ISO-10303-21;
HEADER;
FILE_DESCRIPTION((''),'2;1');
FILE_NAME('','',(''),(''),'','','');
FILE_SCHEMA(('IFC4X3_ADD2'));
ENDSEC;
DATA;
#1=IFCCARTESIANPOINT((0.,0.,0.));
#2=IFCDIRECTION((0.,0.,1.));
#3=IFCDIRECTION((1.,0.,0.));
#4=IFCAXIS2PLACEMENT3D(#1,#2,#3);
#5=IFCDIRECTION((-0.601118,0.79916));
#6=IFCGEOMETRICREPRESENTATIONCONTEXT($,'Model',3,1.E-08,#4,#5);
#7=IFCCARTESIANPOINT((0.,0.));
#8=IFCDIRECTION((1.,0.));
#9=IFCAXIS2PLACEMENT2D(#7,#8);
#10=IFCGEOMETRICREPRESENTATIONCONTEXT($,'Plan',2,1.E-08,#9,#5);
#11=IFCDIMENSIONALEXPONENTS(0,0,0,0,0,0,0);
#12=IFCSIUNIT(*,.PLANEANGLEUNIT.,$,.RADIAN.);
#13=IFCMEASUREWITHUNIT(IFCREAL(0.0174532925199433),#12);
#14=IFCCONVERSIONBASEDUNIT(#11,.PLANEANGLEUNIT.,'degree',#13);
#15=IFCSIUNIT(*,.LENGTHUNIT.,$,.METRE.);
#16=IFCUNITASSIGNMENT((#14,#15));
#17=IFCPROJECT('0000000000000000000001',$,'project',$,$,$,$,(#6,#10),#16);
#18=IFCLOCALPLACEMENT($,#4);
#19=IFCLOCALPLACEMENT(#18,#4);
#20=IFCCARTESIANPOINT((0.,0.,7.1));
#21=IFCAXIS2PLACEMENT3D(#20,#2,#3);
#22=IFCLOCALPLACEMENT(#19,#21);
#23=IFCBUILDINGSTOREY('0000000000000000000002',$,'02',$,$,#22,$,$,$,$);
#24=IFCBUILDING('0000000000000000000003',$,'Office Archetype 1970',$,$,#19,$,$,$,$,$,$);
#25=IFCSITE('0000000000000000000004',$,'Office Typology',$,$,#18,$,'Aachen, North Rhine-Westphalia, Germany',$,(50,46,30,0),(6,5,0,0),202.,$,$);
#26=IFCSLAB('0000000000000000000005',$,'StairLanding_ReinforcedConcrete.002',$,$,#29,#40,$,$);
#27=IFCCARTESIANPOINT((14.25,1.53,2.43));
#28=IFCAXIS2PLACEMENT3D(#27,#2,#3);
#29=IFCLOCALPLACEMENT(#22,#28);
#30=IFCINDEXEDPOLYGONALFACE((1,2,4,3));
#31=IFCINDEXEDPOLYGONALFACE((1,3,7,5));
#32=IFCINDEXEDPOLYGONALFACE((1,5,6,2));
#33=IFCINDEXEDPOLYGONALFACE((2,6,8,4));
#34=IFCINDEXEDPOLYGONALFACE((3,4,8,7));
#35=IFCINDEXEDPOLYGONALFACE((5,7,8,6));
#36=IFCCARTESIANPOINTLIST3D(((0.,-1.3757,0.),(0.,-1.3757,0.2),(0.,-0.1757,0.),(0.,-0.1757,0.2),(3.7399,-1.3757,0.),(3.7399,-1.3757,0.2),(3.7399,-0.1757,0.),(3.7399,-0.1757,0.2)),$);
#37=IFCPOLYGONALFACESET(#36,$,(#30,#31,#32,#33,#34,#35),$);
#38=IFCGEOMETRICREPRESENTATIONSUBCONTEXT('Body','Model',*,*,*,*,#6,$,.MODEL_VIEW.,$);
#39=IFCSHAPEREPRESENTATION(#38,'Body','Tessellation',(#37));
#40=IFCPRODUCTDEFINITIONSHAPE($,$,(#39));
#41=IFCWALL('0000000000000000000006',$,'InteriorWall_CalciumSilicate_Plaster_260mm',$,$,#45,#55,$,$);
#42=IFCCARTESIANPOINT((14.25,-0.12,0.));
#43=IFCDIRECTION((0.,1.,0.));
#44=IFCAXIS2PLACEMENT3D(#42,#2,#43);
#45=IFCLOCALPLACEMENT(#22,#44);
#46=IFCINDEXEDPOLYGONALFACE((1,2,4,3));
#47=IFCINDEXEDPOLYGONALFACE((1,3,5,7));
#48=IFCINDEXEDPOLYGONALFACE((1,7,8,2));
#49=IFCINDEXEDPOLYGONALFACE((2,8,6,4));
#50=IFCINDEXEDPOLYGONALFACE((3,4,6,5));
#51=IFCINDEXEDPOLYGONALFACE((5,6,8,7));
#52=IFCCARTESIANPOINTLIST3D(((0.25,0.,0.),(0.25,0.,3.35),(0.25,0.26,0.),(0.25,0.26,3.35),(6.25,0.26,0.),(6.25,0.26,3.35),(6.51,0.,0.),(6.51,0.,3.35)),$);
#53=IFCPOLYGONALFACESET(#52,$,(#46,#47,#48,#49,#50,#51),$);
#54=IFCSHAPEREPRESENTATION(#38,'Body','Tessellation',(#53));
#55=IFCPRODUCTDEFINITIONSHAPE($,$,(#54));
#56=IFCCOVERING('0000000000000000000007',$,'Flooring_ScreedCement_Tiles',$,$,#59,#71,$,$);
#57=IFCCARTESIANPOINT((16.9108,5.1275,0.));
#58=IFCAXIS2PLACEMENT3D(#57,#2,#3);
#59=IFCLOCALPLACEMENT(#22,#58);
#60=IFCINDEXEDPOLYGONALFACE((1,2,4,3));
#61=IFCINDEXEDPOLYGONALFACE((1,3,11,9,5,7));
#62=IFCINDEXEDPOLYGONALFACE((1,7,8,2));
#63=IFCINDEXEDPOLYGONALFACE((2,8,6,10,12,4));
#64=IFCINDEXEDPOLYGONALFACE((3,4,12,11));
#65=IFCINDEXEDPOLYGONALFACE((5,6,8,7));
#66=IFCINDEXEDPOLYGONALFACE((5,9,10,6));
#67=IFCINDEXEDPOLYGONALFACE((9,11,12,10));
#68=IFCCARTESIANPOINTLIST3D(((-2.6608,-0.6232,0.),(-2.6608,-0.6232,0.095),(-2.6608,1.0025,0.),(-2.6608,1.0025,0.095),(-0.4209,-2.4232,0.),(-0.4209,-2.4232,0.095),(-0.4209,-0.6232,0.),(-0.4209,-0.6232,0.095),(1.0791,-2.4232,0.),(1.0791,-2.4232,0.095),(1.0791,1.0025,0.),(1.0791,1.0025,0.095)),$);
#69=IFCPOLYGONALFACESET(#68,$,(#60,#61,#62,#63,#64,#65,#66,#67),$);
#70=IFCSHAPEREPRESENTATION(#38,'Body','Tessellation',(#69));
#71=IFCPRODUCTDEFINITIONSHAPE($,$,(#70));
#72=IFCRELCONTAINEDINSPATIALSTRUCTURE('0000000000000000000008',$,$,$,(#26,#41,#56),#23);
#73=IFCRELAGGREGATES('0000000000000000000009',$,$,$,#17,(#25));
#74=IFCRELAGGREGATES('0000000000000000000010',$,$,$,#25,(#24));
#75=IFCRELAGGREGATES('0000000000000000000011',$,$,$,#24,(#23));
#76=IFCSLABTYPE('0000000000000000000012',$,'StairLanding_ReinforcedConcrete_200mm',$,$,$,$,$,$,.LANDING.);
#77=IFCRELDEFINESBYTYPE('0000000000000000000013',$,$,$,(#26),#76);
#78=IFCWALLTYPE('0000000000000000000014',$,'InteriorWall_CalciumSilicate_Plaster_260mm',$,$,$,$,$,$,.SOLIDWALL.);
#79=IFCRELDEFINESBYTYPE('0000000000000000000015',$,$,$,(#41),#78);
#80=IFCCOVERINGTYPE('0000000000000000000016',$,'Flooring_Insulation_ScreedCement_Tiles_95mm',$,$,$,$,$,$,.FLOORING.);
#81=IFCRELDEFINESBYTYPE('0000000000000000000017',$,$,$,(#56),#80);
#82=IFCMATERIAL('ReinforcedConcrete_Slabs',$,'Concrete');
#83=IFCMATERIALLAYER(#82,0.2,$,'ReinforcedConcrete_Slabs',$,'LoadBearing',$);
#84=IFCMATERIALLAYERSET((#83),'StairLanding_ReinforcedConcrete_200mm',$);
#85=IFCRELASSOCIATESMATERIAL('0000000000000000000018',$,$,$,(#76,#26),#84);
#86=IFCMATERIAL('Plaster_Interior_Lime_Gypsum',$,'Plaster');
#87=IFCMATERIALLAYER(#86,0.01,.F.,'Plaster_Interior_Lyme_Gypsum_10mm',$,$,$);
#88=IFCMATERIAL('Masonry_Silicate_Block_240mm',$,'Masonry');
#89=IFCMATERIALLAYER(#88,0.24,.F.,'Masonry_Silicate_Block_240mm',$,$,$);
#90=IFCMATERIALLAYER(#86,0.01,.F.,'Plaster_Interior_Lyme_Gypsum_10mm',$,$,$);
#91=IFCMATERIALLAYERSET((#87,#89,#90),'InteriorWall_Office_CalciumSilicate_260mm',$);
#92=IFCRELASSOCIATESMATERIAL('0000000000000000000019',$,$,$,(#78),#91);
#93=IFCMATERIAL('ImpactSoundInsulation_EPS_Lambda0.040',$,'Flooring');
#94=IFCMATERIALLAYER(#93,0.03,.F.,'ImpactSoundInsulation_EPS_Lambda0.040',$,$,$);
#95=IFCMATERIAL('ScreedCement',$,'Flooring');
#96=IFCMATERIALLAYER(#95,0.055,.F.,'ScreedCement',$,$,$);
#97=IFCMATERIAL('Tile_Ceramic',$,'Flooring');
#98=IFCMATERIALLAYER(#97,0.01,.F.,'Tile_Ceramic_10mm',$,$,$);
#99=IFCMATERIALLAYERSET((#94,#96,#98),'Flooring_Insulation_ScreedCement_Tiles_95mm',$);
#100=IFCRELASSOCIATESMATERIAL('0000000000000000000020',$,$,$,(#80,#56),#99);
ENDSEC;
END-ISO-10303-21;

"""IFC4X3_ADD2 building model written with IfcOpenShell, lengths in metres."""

from ifc_helpers import new_model, entity, si_unit, converted_unit, direction, frame, origin_with_axes, origin_2d_with_axis, place, context, subcontext, project, spatial, line, indexed_curve, outline, extrude, material, layer, layer_set, layer_usage, type_object, element, save


model = new_model("IFC4X3_ADD2")

# Units and contexts
model_context = context("Model", 3, precision=1e-08, world=origin_with_axes(), true_north=direction((-0.601118, 0.79916)))
plan_context = context("Plan", 2, precision=1e-08, world=origin_2d_with_axis(), true_north=direction((-0.601118, 0.79916)))
body_context = subcontext(model_context, "Body", "Model", "MODEL_VIEW")
ifc_project = project(units=[converted_unit("PLANEANGLEUNIT", "degree", entity("IfcReal", 0.0174532925199433), si_unit("PLANEANGLEUNIT", "RADIAN"), dimensions=[0, 0, 0, 0, 0, 0, 0]), si_unit("LENGTHUNIT", "METRE")], contexts=[model_context, plan_context])

# Site, building, storey
site_placement = place(None, origin_with_axes())
site = spatial("IfcSite", under=ifc_project, at=site_placement, Name="Office Typology", LongName="Aachen, North Rhine-Westphalia, Germany", RefLatitude=(50, 46, 30, 0), RefLongitude=(6, 5, 0, 0), RefElevation=202.0)
building_placement = place(site_placement, origin_with_axes())
building = spatial("IfcBuilding", under=site, at=building_placement, Name="Office Archetype 1970")
storey_placement = place(building_placement, frame((0.0, 0.0, 7.1), z_axis=(0.0, 0.0, 1.0), x_axis=(1.0, 0.0, 0.0)))
storey = spatial("IfcBuildingStorey", under=building, at=storey_placement, Name="02")

# Slab
ifc_material_1 = material(Name="ReinforcedConcrete_Slabs", Category="Concrete")
ifc_layer_1 = layer(ifc_material_1, 0.2, Name="ReinforcedConcrete_Slabs", Category="LoadBearing")
ifc_layer_set_1 = layer_set([ifc_layer_1], Name="StairLanding_ReinforcedConcrete_200mm")
ifc_layer_usage_1 = layer_usage(ifc_layer_set_1, "AXIS3", "POSITIVE", 0.0)
slab_type_1 = type_object("IfcSlabType", Name="StairLanding_ReinforcedConcrete_200mm", PredefinedType="LANDING", material=ifc_layer_set_1)
slab_1_placement = place(storey_placement, frame((14.25, 1.53, 2.43), z_axis=(0.0, 0.0, 1.0), x_axis=(1.0, 0.0, 0.0)))
element("IfcSlab", 1, at=slab_1_placement, inside=storey, type_object=slab_type_1, material=ifc_layer_usage_1, Name="StairLanding_ReinforcedConcrete.002", context=body_context, shape_type="SweptSolid", body=[
    extrude(outline(indexed_curve([(3.7399, -0.1757), (3.7399, -1.3757), (0.0, -1.3757), (0.0, -0.1757), (3.7399, -0.1757)])), None, (0.0, 0.0, 1.0), 0.2),
])

# Wall
ifc_material_2 = material(Name="Plaster_Interior_Lime_Gypsum", Category="Plaster")
ifc_layer_2 = layer(ifc_material_2, 0.01, ventilated=False, Name="Plaster_Interior_Lyme_Gypsum_10mm")
ifc_material_3 = material(Name="Masonry_Silicate_Block_240mm", Category="Masonry")
ifc_layer_3 = layer(ifc_material_3, 0.24, ventilated=False, Name="Masonry_Silicate_Block_240mm")
ifc_layer_4 = layer(ifc_material_2, 0.01, ventilated=False, Name="Plaster_Interior_Lyme_Gypsum_10mm")
ifc_layer_set_2 = layer_set([ifc_layer_2, ifc_layer_3, ifc_layer_4], Name="InteriorWall_Office_CalciumSilicate_260mm")
wall_type = type_object("IfcWallType", Name="InteriorWall_CalciumSilicate_Plaster_260mm", PredefinedType="SOLIDWALL", material=ifc_layer_set_2)
wall_placement = place(storey_placement, frame((14.25, -0.12, 0.0), z_axis=(0.0, 0.0, 1.0), x_axis=(0.0, 1.0, 0.0)))
element("IfcWall", 2, at=wall_placement, inside=storey, type_object=wall_type, Name="InteriorWall_CalciumSilicate_Plaster_260mm", context=body_context, shape_type="SweptSolid", body=[
    extrude(outline(indexed_curve([(0.25, 0.0), (0.25, 0.26), (6.25, 0.26), (6.51, 0.0)], segments=[line(1, 2, 3, 4, 1)])), origin_with_axes(), (0.0, 0.0, 1.0), 3.35),
])

# Covering
ifc_material_4 = material(Name="ImpactSoundInsulation_EPS_Lambda0.040", Category="Flooring")
ifc_layer_5 = layer(ifc_material_4, 0.03, ventilated=False, Name="ImpactSoundInsulation_EPS_Lambda0.040")
ifc_material_5 = material(Name="ScreedCement", Category="Flooring")
ifc_layer_6 = layer(ifc_material_5, 0.055, ventilated=False, Name="ScreedCement")
ifc_material_6 = material(Name="Tile_Ceramic", Category="Flooring")
ifc_layer_7 = layer(ifc_material_6, 0.01, ventilated=False, Name="Tile_Ceramic_10mm")
ifc_layer_set_3 = layer_set([ifc_layer_5, ifc_layer_6, ifc_layer_7], Name="Flooring_Insulation_ScreedCement_Tiles_95mm")
ifc_layer_usage_2 = layer_usage(ifc_layer_set_3, "AXIS3", "POSITIVE", 0.0)
covering_type = type_object("IfcCoveringType", Name="Flooring_Insulation_ScreedCement_Tiles_95mm", PredefinedType="FLOORING", material=ifc_layer_set_3)
covering_placement = place(storey_placement, frame((16.9108, 5.1275, 0.0), z_axis=(0.0, 0.0, 1.0), x_axis=(1.0, 0.0, 0.0)))
element("IfcCovering", 3, at=covering_placement, inside=storey, type_object=covering_type, material=ifc_layer_usage_2, Name="Flooring_ScreedCement_Tiles", context=body_context, shape_type="SweptSolid", body=[
    extrude(outline(indexed_curve([(-2.6608, 1.0025), (-2.6608, -0.6232), (-0.4209, -0.6232), (-0.4209, -2.4232), (1.0791, -2.4232), (1.0791, 1.0025)], segments=[line(1, 2, 3, 4, 5, 6, 1)])), None, (0.0, 0.0, 1.0), 0.095),
])

save(model, "model.ifc")
